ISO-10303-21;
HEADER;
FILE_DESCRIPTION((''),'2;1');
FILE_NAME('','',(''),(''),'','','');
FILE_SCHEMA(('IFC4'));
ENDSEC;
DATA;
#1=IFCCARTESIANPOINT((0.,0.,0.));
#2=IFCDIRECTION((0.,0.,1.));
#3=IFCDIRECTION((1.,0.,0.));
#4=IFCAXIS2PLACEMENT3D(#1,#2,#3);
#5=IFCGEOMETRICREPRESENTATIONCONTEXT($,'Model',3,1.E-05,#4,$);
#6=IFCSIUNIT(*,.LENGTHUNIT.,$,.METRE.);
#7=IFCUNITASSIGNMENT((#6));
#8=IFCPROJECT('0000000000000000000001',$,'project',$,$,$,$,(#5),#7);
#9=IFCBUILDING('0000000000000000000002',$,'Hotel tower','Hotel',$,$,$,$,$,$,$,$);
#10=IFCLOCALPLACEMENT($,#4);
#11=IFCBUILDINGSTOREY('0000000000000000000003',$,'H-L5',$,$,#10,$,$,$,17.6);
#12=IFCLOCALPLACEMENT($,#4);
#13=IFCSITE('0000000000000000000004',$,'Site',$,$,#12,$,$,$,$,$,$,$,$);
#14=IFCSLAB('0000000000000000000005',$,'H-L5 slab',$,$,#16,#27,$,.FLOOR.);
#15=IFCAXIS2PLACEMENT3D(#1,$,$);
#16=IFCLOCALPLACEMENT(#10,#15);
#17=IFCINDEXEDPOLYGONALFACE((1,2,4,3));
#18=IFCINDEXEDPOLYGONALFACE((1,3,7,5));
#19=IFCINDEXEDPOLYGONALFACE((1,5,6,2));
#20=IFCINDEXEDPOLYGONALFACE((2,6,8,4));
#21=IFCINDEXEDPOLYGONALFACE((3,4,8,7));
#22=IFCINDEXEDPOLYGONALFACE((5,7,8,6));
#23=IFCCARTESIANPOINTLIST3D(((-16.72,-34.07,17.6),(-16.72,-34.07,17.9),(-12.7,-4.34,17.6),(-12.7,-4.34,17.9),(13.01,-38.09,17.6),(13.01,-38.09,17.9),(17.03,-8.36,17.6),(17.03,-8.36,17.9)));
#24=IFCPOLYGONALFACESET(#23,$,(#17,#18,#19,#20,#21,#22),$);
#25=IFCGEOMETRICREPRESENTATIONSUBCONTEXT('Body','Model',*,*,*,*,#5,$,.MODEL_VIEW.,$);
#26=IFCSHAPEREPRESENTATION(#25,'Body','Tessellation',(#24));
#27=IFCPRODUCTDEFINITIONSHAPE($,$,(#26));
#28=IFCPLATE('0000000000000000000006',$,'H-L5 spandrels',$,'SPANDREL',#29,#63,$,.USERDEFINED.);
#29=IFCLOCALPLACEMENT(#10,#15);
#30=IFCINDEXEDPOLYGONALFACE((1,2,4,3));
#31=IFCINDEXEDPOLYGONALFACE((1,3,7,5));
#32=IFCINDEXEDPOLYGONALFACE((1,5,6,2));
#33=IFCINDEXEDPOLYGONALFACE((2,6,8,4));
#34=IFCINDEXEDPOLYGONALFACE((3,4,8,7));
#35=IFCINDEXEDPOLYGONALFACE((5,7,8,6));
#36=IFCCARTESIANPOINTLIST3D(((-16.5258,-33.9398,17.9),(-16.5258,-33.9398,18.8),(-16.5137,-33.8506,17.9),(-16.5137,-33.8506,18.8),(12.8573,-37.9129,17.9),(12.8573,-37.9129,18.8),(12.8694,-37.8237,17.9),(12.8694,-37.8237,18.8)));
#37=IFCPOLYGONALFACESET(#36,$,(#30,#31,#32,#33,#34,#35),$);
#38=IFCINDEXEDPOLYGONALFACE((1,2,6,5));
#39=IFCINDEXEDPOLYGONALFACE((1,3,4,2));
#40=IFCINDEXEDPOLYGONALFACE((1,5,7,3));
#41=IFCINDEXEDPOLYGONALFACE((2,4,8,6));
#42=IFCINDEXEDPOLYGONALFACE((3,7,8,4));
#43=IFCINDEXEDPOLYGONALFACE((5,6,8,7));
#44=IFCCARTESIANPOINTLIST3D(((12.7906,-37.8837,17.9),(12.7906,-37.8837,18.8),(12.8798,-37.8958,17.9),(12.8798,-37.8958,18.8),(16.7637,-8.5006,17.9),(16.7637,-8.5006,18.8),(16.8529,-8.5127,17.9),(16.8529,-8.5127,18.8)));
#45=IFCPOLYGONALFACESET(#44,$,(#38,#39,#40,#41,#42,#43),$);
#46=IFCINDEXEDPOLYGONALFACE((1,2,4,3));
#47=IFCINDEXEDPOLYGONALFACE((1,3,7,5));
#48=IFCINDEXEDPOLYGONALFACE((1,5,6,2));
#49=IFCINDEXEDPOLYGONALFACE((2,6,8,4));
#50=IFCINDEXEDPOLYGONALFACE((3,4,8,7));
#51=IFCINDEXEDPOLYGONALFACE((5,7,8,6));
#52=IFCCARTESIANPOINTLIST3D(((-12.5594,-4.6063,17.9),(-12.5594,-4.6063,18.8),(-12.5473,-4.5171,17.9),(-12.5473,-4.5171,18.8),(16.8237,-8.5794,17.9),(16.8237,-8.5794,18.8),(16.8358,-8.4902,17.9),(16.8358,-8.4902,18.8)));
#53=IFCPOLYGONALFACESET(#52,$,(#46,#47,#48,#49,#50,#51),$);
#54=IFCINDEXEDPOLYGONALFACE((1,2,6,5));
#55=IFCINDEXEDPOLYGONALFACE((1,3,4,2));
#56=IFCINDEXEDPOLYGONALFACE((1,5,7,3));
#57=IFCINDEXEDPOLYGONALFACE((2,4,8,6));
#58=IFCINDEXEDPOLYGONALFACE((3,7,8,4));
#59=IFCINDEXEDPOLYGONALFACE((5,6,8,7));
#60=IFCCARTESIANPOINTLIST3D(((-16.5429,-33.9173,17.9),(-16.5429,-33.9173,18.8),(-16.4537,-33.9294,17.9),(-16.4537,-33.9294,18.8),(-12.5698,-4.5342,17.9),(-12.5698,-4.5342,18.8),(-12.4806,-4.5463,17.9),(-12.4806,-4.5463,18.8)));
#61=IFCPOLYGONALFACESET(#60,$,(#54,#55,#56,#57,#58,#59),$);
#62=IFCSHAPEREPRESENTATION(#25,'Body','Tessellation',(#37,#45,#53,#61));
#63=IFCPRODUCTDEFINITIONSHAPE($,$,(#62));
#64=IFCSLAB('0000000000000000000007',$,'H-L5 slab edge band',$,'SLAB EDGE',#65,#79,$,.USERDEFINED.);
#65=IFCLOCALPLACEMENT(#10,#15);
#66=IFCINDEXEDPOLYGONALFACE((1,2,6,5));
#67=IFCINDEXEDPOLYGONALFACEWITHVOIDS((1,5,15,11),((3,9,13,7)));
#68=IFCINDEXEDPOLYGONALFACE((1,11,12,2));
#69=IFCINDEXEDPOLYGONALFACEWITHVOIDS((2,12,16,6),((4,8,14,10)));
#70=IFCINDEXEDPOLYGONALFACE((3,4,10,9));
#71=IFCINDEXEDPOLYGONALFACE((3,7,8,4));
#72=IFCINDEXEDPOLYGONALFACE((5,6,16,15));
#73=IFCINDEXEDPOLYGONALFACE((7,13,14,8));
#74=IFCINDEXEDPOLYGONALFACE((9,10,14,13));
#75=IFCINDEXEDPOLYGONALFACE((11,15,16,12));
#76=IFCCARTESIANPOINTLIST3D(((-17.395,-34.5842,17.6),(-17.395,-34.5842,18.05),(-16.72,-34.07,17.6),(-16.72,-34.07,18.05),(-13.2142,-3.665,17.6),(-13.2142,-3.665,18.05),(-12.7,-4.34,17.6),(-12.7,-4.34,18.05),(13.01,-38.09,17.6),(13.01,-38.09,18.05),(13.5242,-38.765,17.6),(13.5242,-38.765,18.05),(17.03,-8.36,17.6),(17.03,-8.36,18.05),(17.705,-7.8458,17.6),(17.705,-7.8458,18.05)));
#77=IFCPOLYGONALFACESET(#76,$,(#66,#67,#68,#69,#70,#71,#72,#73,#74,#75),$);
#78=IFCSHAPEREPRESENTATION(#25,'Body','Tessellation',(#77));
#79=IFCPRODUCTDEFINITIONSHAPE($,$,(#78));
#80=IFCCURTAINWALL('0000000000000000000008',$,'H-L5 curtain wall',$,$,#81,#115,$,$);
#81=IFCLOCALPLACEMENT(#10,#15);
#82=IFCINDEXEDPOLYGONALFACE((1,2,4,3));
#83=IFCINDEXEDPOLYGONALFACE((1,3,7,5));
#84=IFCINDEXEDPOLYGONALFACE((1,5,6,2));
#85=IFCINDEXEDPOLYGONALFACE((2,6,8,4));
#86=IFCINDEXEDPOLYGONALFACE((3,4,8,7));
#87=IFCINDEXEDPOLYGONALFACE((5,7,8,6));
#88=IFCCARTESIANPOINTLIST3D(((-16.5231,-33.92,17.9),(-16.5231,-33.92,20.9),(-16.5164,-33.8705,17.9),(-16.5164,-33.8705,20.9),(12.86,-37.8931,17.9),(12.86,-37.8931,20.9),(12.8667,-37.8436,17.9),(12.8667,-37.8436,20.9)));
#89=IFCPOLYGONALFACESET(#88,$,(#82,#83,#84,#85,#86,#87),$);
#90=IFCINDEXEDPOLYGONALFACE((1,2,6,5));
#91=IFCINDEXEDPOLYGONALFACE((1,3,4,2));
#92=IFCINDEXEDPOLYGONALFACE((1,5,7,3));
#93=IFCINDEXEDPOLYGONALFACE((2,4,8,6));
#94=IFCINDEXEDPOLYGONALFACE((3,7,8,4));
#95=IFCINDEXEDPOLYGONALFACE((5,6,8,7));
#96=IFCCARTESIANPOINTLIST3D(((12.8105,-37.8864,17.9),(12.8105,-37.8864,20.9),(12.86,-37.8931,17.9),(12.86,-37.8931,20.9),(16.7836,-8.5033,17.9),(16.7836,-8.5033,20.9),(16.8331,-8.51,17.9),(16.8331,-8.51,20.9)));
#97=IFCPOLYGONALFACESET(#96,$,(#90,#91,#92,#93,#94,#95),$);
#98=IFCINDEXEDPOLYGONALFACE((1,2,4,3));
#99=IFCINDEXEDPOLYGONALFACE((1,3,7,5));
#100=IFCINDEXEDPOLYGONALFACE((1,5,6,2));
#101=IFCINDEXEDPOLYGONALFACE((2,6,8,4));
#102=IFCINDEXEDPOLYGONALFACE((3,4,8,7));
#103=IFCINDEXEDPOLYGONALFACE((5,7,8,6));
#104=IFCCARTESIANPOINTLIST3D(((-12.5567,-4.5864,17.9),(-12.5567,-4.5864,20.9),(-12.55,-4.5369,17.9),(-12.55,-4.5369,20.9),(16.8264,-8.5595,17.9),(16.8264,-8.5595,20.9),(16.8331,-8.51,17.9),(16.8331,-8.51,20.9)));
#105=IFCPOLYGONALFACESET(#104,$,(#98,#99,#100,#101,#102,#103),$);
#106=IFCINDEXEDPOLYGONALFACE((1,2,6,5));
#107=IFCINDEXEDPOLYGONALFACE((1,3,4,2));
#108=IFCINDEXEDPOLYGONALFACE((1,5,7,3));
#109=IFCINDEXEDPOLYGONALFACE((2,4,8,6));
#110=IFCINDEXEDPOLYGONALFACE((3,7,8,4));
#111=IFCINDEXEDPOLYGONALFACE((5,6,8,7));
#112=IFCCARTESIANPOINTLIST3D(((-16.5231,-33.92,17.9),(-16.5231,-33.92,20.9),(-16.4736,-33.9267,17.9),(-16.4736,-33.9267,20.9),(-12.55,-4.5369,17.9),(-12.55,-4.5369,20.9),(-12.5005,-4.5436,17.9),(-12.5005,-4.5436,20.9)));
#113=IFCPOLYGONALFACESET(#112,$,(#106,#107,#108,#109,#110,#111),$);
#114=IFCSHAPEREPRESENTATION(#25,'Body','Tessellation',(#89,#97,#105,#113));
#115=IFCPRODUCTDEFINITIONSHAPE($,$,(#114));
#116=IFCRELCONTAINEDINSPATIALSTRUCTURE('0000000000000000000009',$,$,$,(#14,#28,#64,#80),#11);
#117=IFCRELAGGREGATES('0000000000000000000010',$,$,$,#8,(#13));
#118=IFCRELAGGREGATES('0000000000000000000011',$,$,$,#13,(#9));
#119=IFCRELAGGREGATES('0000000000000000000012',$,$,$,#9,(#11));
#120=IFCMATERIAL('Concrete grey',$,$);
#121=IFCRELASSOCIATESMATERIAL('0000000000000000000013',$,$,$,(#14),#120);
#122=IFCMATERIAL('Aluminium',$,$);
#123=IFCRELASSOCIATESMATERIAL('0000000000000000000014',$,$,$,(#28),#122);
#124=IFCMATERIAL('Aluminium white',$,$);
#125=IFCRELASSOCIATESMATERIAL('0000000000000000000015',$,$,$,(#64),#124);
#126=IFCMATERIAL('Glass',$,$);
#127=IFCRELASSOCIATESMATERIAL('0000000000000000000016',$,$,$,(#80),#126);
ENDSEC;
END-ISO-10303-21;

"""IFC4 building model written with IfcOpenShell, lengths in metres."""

from ifc_helpers import new_model, si_unit, frame, origin_with_axes, place, context, subcontext, project, spatial, polyline, outline, extrude, material, element, save


model = new_model("IFC4")

# Units and contexts
model_context = context("Model", 3, precision=1e-05, world=origin_with_axes())
body_context = subcontext(model_context, "Body", "Model", "MODEL_VIEW")
ifc_project = project(units=[si_unit("LENGTHUNIT", "METRE")], contexts=[model_context])

# Site, building, storey
site_placement = place(None, origin_with_axes())
site = spatial("IfcSite", under=ifc_project, at=site_placement, Name="Site")
building = spatial("IfcBuilding", under=site, Name="Hotel tower", Description="Hotel")
storey_placement = place(None, origin_with_axes())
storey = spatial("IfcBuildingStorey", under=building, at=storey_placement, Name="H-L5", Elevation=17.6)

# Shared definitions
ifc_material_1 = material(Name="Aluminium")

# Slab
ifc_material_2 = material(Name="Concrete grey")
slab_1_placement = place(storey_placement, origin_with_axes())
element("IfcSlab", 1, at=slab_1_placement, inside=storey, material=ifc_material_2, Name="H-L5 slab", PredefinedType="FLOOR", context=body_context, shape_type="SweptSolid", body=[
    extrude(outline(polyline([(-16.72, -34.07), (13.01, -38.09), (17.03, -8.36), (-12.7, -4.34), (-16.72, -34.07)])), frame((0.0, 0.0, 17.6), z_axis=(0.0, 0.0, 1.0), x_axis=(1.0, 0.0, 0.0)), (0.0, 0.0, 1.0), 0.3),
])

# Plate
plate_placement = place(storey_placement, origin_with_axes())
element("IfcPlate", 2, at=plate_placement, inside=storey, material=ifc_material_1, Name="H-L5 spandrels", ObjectType="SPANDREL", PredefinedType="USERDEFINED", context=body_context, shape_type="SweptSolid", body=[
    extrude(outline(polyline([(-16.5258, -33.9398), (12.8573, -37.9129), (12.8694, -37.8237), (-16.5137, -33.8506), (-16.5258, -33.9398)])), frame((0.0, 0.0, 17.9), z_axis=(0.0, 0.0, 1.0), x_axis=(1.0, 0.0, 0.0)), (0.0, 0.0, 1.0), 0.9),
    extrude(outline(polyline([(12.8798, -37.8958), (16.8529, -8.5127), (16.7637, -8.5006), (12.7906, -37.8837), (12.8798, -37.8958)])), frame((0.0, 0.0, 17.9), z_axis=(0.0, 0.0, 1.0), x_axis=(1.0, 0.0, 0.0)), (0.0, 0.0, 1.0), 0.9),
    extrude(outline(polyline([(16.8358, -8.4902), (-12.5473, -4.5171), (-12.5594, -4.6063), (16.8237, -8.5794), (16.8358, -8.4902)])), frame((0.0, 0.0, 17.9), z_axis=(0.0, 0.0, 1.0), x_axis=(1.0, 0.0, 0.0)), (0.0, 0.0, 1.0), 0.9),
    extrude(outline(polyline([(-12.5698, -4.5342), (-16.5429, -33.9173), (-16.4537, -33.9294), (-12.4806, -4.5463), (-12.5698, -4.5342)])), frame((0.0, 0.0, 17.9), z_axis=(0.0, 0.0, 1.0), x_axis=(1.0, 0.0, 0.0)), (0.0, 0.0, 1.0), 0.9),
])

# Slab
ifc_material_3 = material(Name="Aluminium white")
slab_2_placement = place(storey_placement, origin_with_axes())
element("IfcSlab", 3, at=slab_2_placement, inside=storey, material=ifc_material_3, Name="H-L5 slab edge band", ObjectType="SLAB EDGE", PredefinedType="USERDEFINED", context=body_context, shape_type="SweptSolid", body=[
    extrude(outline(polyline([(-17.395, -34.5842), (13.5242, -38.765), (17.705, -7.8458), (-13.2142, -3.665), (-17.395, -34.5842)]), holes=[polyline([(-16.72, -34.07), (13.01, -38.09), (17.03, -8.36), (-12.7, -4.34), (-16.72, -34.07)])]), frame((0.0, 0.0, 17.6), z_axis=(0.0, 0.0, 1.0), x_axis=(1.0, 0.0, 0.0)), (0.0, 0.0, 1.0), 0.45),
])

# Curtain wall
ifc_material_4 = material(Name="Glass")
curtain_wall_placement = place(storey_placement, origin_with_axes())
element("IfcCurtainWall", 4, at=curtain_wall_placement, inside=storey, material=ifc_material_4, Name="H-L5 curtain wall", context=body_context, shape_type="SweptSolid", body=[
    extrude(outline(polyline([(-16.5231, -33.92), (12.86, -37.8931), (12.8667, -37.8436), (-16.5164, -33.8705), (-16.5231, -33.92)])), frame((0.0, 0.0, 17.9), z_axis=(0.0, 0.0, 1.0), x_axis=(1.0, 0.0, 0.0)), (0.0, 0.0, 1.0), 3.0),
    extrude(outline(polyline([(12.86, -37.8931), (16.8331, -8.51), (16.7836, -8.5033), (12.8105, -37.8864), (12.86, -37.8931)])), frame((0.0, 0.0, 17.9), z_axis=(0.0, 0.0, 1.0), x_axis=(1.0, 0.0, 0.0)), (0.0, 0.0, 1.0), 3.0),
    extrude(outline(polyline([(16.8331, -8.51), (-12.55, -4.5369), (-12.5567, -4.5864), (16.8264, -8.5595), (16.8331, -8.51)])), frame((0.0, 0.0, 17.9), z_axis=(0.0, 0.0, 1.0), x_axis=(1.0, 0.0, 0.0)), (0.0, 0.0, 1.0), 3.0),
    extrude(outline(polyline([(-12.55, -4.5369), (-16.5231, -33.92), (-16.4736, -33.9267), (-12.5005, -4.5436), (-12.55, -4.5369)])), frame((0.0, 0.0, 17.9), z_axis=(0.0, 0.0, 1.0), x_axis=(1.0, 0.0, 0.0)), (0.0, 0.0, 1.0), 3.0),
])

save(model, "model.ifc")
